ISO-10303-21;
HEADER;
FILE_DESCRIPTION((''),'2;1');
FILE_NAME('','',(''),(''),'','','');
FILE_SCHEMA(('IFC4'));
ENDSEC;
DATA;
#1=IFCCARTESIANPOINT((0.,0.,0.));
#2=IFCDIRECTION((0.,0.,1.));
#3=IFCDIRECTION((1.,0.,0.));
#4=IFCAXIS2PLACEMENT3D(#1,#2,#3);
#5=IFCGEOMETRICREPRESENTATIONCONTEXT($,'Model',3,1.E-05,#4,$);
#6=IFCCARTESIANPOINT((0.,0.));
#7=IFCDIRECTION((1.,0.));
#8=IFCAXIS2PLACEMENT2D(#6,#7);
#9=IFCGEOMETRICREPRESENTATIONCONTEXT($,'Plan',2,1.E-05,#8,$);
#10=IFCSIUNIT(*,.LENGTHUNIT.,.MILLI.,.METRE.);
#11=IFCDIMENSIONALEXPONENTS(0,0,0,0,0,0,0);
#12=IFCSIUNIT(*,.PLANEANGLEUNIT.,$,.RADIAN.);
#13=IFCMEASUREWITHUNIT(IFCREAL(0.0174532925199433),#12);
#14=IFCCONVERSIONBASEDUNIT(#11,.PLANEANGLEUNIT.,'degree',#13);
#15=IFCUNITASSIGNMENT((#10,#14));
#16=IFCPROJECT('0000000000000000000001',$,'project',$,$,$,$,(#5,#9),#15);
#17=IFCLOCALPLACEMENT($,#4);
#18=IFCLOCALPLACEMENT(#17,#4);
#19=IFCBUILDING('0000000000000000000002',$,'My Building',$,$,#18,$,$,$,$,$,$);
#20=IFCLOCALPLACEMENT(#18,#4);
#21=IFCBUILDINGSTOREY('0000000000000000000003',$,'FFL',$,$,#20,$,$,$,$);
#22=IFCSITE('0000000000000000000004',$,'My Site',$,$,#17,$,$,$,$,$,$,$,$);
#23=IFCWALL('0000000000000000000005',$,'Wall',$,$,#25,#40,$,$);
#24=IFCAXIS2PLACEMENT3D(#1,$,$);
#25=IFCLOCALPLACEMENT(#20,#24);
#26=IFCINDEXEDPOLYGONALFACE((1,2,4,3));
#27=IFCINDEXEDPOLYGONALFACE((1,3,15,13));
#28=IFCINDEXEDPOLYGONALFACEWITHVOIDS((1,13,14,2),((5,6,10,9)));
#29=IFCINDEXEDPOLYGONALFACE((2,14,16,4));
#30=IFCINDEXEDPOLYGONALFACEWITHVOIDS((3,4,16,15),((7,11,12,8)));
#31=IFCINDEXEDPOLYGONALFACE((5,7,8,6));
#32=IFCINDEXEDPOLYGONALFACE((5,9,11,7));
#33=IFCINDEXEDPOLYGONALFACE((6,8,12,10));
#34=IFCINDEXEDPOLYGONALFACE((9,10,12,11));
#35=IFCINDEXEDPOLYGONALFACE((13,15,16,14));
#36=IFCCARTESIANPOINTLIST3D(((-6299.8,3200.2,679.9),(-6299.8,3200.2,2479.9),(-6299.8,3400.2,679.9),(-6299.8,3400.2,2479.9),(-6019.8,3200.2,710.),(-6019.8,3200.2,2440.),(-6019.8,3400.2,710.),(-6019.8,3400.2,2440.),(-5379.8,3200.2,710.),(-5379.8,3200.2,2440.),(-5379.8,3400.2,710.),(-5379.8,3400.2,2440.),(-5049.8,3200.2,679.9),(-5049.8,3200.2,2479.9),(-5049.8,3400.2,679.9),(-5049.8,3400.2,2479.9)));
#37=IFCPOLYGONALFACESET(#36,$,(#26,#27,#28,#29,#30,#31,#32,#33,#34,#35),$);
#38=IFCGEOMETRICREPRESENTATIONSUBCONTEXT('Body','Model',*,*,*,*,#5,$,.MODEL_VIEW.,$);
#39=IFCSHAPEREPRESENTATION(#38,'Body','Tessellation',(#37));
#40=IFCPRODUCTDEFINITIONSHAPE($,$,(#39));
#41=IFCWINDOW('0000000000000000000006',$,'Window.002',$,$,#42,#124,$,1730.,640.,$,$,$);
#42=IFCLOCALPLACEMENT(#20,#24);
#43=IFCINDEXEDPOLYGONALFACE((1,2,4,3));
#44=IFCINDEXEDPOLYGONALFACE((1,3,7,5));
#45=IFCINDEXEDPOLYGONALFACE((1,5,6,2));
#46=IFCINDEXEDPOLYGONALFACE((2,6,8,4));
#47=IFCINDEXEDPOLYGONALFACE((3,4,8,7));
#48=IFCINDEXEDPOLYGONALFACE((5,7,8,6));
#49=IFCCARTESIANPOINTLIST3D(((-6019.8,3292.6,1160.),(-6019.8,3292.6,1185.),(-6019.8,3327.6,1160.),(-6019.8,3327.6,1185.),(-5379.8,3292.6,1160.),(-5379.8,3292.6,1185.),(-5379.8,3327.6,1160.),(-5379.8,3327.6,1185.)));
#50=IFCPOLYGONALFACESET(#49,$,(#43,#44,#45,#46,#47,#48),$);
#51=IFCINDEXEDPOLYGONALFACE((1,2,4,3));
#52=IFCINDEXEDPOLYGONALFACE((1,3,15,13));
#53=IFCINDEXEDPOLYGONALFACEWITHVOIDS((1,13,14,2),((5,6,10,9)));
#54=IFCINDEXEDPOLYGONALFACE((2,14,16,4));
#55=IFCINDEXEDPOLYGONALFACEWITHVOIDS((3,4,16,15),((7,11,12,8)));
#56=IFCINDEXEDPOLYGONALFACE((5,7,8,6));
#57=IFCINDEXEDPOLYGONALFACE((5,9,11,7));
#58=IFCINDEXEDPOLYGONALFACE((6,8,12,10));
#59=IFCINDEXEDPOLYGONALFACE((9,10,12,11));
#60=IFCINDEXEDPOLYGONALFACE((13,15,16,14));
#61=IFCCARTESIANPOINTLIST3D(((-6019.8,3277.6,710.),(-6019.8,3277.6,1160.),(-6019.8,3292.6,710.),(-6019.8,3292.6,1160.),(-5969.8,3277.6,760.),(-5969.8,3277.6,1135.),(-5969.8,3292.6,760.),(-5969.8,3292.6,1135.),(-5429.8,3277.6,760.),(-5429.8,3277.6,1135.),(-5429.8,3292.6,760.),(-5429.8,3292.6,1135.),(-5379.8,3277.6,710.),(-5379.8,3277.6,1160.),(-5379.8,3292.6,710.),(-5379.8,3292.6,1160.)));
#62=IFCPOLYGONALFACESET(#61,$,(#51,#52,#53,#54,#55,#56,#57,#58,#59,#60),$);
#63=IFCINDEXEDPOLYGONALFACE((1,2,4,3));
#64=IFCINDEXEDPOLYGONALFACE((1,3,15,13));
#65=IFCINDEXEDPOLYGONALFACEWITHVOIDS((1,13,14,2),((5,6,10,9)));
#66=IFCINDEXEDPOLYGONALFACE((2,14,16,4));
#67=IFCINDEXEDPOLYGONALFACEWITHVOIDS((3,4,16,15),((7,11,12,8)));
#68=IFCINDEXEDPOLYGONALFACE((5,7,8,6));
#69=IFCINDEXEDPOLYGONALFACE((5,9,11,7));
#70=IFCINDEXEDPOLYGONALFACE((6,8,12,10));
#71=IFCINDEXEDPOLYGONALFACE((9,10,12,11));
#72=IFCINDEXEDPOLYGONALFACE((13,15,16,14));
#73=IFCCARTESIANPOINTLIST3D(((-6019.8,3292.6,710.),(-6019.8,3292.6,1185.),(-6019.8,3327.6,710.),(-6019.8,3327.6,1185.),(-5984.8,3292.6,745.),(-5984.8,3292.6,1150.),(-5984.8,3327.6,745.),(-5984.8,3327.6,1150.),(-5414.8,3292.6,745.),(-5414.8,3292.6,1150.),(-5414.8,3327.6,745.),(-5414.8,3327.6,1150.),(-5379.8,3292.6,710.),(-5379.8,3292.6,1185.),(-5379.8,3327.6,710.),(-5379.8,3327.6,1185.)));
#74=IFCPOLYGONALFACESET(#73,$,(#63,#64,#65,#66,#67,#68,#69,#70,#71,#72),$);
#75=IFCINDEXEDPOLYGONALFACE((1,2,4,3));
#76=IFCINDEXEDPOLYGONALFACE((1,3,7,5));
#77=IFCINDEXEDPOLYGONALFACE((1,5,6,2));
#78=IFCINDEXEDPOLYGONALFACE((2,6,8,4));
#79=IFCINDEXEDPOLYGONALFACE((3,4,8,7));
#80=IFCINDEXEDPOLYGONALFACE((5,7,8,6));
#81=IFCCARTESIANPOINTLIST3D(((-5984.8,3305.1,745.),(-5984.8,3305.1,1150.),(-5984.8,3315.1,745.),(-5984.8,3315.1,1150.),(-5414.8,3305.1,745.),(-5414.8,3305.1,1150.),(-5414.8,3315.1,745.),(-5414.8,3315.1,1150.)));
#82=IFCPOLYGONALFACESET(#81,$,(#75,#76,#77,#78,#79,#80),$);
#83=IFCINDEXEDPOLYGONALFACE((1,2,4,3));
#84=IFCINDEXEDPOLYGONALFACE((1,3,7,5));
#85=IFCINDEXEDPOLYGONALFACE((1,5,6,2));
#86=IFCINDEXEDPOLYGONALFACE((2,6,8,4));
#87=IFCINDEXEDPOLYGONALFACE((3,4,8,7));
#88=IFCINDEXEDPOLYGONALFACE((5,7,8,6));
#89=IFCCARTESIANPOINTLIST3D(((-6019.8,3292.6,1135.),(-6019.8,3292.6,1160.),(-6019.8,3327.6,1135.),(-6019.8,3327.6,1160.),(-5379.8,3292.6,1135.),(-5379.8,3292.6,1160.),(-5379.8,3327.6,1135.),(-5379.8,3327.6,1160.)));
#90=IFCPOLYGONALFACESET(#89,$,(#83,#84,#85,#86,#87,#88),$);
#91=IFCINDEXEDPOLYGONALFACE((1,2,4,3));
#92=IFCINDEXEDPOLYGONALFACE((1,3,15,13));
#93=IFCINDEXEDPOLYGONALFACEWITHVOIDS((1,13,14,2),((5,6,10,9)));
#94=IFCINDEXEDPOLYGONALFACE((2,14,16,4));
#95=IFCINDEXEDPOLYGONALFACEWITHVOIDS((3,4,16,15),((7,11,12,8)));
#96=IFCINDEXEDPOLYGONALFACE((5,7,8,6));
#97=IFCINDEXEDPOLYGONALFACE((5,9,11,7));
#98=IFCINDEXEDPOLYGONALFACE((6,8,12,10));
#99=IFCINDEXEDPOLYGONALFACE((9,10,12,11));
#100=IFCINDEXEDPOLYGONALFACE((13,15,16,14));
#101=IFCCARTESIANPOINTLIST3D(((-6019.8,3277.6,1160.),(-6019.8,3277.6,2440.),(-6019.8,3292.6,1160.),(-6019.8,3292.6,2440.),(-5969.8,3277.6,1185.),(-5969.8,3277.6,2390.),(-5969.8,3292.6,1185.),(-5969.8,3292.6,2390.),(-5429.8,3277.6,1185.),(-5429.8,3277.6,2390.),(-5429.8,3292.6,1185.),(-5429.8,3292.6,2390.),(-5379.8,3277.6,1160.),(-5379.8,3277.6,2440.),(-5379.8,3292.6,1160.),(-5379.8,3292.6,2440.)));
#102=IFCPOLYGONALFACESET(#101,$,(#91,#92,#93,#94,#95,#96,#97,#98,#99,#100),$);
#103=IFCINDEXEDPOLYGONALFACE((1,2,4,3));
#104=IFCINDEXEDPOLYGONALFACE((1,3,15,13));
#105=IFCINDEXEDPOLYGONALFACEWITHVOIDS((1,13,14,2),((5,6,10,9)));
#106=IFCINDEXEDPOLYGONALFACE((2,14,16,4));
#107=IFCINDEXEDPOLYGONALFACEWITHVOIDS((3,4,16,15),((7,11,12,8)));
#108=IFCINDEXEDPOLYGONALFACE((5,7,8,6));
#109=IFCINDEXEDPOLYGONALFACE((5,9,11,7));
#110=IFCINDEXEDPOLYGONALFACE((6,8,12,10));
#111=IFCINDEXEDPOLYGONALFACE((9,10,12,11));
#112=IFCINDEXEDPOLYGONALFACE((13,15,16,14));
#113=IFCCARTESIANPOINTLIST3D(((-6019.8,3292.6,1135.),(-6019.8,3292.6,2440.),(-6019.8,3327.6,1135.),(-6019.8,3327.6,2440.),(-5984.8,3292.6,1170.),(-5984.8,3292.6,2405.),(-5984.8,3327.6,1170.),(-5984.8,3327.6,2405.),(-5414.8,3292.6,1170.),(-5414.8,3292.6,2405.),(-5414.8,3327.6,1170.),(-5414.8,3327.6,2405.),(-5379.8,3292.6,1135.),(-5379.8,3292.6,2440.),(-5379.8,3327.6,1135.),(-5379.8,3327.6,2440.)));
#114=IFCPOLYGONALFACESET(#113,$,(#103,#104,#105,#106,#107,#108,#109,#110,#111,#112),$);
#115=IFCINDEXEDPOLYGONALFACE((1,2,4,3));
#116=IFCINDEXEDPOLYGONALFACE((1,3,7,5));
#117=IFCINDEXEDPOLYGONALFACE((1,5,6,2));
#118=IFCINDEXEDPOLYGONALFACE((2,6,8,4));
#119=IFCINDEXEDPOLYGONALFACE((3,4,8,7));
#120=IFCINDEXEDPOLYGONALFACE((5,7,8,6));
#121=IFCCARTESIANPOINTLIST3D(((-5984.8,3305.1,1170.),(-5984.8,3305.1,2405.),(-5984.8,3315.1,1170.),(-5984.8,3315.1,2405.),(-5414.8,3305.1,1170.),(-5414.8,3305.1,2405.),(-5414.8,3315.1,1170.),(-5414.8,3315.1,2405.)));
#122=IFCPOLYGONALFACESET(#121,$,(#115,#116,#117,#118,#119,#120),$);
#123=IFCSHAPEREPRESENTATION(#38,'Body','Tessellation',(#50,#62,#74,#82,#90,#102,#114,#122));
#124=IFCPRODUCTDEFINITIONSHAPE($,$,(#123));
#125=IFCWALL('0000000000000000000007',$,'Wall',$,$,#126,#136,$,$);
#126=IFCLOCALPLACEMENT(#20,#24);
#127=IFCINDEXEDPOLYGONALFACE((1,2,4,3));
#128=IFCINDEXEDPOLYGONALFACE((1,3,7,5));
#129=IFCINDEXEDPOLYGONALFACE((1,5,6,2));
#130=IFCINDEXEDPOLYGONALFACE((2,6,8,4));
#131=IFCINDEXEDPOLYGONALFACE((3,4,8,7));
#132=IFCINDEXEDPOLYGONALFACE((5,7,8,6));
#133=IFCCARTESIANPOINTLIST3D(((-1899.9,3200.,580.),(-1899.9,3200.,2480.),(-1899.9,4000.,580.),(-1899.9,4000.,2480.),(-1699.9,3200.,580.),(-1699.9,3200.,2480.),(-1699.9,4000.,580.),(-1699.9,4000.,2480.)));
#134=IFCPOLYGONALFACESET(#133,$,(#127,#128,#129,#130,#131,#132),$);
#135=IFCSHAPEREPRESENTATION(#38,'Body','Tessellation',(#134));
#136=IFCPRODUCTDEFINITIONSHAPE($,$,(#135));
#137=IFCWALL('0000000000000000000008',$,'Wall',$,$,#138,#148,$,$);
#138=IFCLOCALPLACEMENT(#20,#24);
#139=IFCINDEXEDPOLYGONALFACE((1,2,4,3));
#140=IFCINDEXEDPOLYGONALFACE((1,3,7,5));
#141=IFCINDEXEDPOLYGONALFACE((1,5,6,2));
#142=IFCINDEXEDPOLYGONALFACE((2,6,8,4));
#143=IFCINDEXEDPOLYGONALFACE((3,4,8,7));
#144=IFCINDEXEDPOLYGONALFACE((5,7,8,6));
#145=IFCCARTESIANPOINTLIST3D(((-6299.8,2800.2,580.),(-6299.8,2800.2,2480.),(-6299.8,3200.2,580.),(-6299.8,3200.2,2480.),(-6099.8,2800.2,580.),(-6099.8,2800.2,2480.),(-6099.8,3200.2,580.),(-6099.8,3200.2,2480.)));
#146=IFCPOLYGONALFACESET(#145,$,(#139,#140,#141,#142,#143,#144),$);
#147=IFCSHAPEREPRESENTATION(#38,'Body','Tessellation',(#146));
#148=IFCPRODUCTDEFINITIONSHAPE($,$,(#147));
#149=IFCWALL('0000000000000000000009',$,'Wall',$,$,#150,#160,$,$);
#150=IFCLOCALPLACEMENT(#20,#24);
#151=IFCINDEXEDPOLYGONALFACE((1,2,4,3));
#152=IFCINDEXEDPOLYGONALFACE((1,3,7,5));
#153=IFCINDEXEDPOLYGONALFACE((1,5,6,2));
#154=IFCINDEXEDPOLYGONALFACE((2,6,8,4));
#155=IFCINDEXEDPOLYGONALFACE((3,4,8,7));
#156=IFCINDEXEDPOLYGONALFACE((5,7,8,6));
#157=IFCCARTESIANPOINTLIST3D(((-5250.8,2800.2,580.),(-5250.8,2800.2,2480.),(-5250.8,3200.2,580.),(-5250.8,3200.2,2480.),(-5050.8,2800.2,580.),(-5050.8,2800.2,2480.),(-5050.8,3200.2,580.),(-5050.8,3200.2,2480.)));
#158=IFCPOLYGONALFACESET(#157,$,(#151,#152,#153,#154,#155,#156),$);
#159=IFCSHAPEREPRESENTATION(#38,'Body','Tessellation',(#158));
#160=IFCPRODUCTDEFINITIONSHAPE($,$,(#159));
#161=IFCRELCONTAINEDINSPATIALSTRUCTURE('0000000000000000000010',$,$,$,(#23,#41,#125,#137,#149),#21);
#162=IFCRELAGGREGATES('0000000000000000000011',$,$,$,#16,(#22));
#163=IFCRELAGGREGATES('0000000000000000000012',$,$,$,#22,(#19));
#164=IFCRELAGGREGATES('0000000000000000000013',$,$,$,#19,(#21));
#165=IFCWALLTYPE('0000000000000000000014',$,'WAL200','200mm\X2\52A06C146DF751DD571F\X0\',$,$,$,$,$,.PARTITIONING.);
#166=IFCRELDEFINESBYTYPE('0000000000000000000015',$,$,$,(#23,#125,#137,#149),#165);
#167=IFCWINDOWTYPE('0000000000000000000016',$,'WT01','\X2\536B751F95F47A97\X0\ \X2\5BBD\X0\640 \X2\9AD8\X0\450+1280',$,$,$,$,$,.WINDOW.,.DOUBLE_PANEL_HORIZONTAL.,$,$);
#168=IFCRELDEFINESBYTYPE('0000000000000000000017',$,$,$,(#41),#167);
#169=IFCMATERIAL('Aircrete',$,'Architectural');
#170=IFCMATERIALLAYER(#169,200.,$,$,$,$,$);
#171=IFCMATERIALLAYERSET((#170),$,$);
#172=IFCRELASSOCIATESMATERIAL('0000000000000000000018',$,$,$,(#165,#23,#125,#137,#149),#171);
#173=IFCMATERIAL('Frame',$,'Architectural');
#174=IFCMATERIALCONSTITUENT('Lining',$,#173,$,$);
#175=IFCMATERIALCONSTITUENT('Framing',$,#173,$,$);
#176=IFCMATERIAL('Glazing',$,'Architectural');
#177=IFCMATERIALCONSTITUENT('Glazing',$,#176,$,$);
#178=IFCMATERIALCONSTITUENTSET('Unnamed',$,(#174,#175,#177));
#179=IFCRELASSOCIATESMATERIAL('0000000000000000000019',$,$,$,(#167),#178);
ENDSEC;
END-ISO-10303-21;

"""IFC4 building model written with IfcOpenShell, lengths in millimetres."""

from ifc_helpers import new_model, entity, si_unit, converted_unit, frame, origin_with_axes, origin_2d_with_axis, place, context, subcontext, project, spatial, line, indexed_curve, outline, extrude, shape, source, transform, mapped, material, layer, layer_set, layer_usage, constituent, constituent_set, type_object, type_shapes, element, fill, save


model = new_model("IFC4")

# Units and contexts
model_context = context("Model", 3, precision=1e-05, world=origin_with_axes())
plan_context = context("Plan", 2, precision=1e-05, world=origin_2d_with_axis())
body_context_1 = subcontext(model_context, "Body", "Model", "MODEL_VIEW")
body_context_2 = subcontext(plan_context, "Body", "Plan", "PLAN_VIEW")
ifc_project = project(units=[si_unit("LENGTHUNIT", "METRE", prefix="MILLI"), converted_unit("PLANEANGLEUNIT", "degree", entity("IfcReal", 0.0174532925199433), si_unit("PLANEANGLEUNIT", "RADIAN"), dimensions=[0, 0, 0, 0, 0, 0, 0])], contexts=[model_context, plan_context])

# Site, building, storey
site_placement = place(None, origin_with_axes())
site = spatial("IfcSite", under=ifc_project, at=site_placement, Name="My Site")
building_placement = place(site_placement, origin_with_axes())
building = spatial("IfcBuilding", under=site, at=building_placement, Name="My Building")
storey_placement = place(building_placement, origin_with_axes())
storey = spatial("IfcBuildingStorey", under=building, at=storey_placement, Name="FFL")

# Shared definitions
ifc_material_1 = material(Name="Aircrete", Category="Architectural")

# Shared definitions
ifc_layer_1 = layer(ifc_material_1, 200.0)
ifc_layer_set_1 = layer_set([ifc_layer_1])
wall_type_1 = type_object("IfcWallType", Name="WAL200", Description="200mm加气混凝土", PredefinedType="PARTITIONING", material=ifc_layer_set_1)

# Wall, opening, window
ifc_layer_usage_1 = layer_usage(ifc_layer_set_1, "AXIS2", "NEGATIVE", 0.0)
wall_1_placement = place(storey_placement, frame((-6299.8, 3400.2, 679.9), z_axis=(0.0, 0.0, 1.0), x_axis=(1.0, 0.0, 0.0)))
wall_1 = element("IfcWall", 1, at=wall_1_placement, inside=storey, type_object=wall_type_1, material=ifc_layer_usage_1, Name="Wall", context=body_context_1, shape_type="SweptSolid", body=[
    extrude(outline(indexed_curve([(0.0, -200.0), (0.0, 0.0), (1250.0, 0.0), (1250.0, -200.0)], segments=[line(1, 2, 3, 4, 1)])), origin_with_axes(), (0.0, 0.0, 1.0), 1800.0),
])
shared_shape_1 = source(origin_with_axes(), body_context_1, "Body", "SweptSolid", [
    extrude(outline(indexed_curve([(0.0, 0.0), (640.0, 0.0), (640.0, 1730.0), (0.0, 1730.0)], segments=[line(1, 2, 3, 4, 1)])), frame((0.0, -600.0, 0.0), z_axis=(0.0, -1.0, 0.0), x_axis=(1.0, 0.0, 0.0)), (0.0, 0.0, -1.0), 1200.0),
])
opening_1_placement = place(wall_1_placement, frame((280.0, -172.6, 30.1), z_axis=(0.0, 0.0, 1.0), x_axis=(1.0, 0.0, 0.0)))
opening_1 = element("IfcOpeningElement", 2, at=opening_1_placement, cuts=wall_1, PredefinedType="OPENING", context=body_context_1, shape_type="MappedRepresentation", body=[
    mapped(shared_shape_1, transform((0.0, 0.0, 0.0), x_axis=(1.0, 0.0, 0.0), y_axis=(0.0, 1.0, 0.0), z_axis=(0.0, 0.0, 1.0), scale=1.0)),
])
ifc_material_2 = material(Name="Frame", Category="Architectural")
ifc_constituent_1 = constituent(ifc_material_2, Name="Lining")
ifc_constituent_2 = constituent(ifc_material_2, Name="Framing")
ifc_material_3 = material(Name="Glazing", Category="Architectural")
ifc_constituent_3 = constituent(ifc_material_3, Name="Glazing")
ifc_constituent_set_1 = constituent_set(constituents=[ifc_constituent_1, ifc_constituent_2, ifc_constituent_3], Name="Unnamed")
window_type_1 = type_object("IfcWindowType", Name="WT01", Description="卫生间窗 宽640 高450+1280", PartitioningType="DOUBLE_PANEL_HORIZONTAL", PredefinedType="WINDOW", material=ifc_constituent_set_1)
shared_shape_2 = source(origin_with_axes(), body_context_1, "Body", "SweptSolid", [
    extrude(outline(indexed_curve([(0.0, 450.0), (640.0, 450.0), (640.0, 475.0), (0.0, 475.0)], segments=[line(1, 2, 3, 4, 1)])), frame((0.0, 65.0, 0.0), z_axis=(0.0, -1.0, 0.0), x_axis=(1.0, 0.0, 0.0)), (0.0, 0.0, -1.0), 35.0),
    extrude(outline(indexed_curve([(0.0, 0.0), (640.0, 0.0), (640.0, 450.0), (0.0, 450.0)], segments=[line(1, 2, 3, 4, 1)]), holes=[indexed_curve([(50.0, 50.0), (590.0, 50.0), (590.0, 425.0), (50.0, 425.0)], segments=[line(1, 2, 3, 4, 1)])]), frame((0.0, 50.0, 0.0), z_axis=(0.0, -1.0, 0.0), x_axis=(1.0, 0.0, 0.0)), (0.0, 0.0, -1.0), 15.0),
    extrude(outline(indexed_curve([(0.0, 0.0), (640.0, 0.0), (640.0, 475.0), (0.0, 475.0)], segments=[line(1, 2, 3, 4, 1)]), holes=[indexed_curve([(35.0, 35.0), (605.0, 35.0), (605.0, 440.0), (35.0, 440.0)], segments=[line(1, 2, 3, 4, 1)])]), frame((0.0, 65.0, 0.0), z_axis=(0.0, -1.0, 0.0), x_axis=(1.0, 0.0, 0.0)), (0.0, 0.0, -1.0), 35.0),
    extrude(outline(indexed_curve([(35.0, 35.0), (605.0, 35.0), (605.0, 440.0), (35.0, 440.0)], segments=[line(1, 2, 3, 4, 1)])), frame((0.0, 77.5, 0.0), z_axis=(0.0, -1.0, 0.0), x_axis=(1.0, 0.0, 0.0)), (0.0, 0.0, -1.0), 10.0),
    extrude(outline(indexed_curve([(640.0, 0.0), (0.0, 0.0), (0.0, -25.0), (640.0, -25.0)], segments=[line(1, 2, 3, 4, 1)])), frame((0.0, 65.0, 450.0), z_axis=(0.0, -1.0, 0.0), x_axis=(1.0, 0.0, 0.0)), (0.0, 0.0, -1.0), 35.0),
    extrude(outline(indexed_curve([(0.0, 0.0), (640.0, 0.0), (640.0, 1280.0), (0.0, 1280.0)], segments=[line(1, 2, 3, 4, 1)]), holes=[indexed_curve([(50.0, 25.0), (590.0, 25.0), (590.0, 1230.0), (50.0, 1230.0)], segments=[line(1, 2, 3, 4, 1)])]), frame((0.0, 50.0, 450.0), z_axis=(0.0, -1.0, 0.0), x_axis=(1.0, 0.0, 0.0)), (0.0, 0.0, -1.0), 15.0),
    extrude(outline(indexed_curve([(0.0, 0.0), (640.0, 0.0), (640.0, 1305.0), (0.0, 1305.0)], segments=[line(1, 2, 3, 4, 1)]), holes=[indexed_curve([(35.0, 35.0), (605.0, 35.0), (605.0, 1270.0), (35.0, 1270.0)], segments=[line(1, 2, 3, 4, 1)])]), frame((0.0, 65.0, 425.0), z_axis=(0.0, -1.0, 0.0), x_axis=(1.0, 0.0, 0.0)), (0.0, 0.0, -1.0), 35.0),
    extrude(outline(indexed_curve([(35.0, 35.0), (605.0, 35.0), (605.0, 1270.0), (35.0, 1270.0)], segments=[line(1, 2, 3, 4, 1)])), frame((0.0, 77.5, 425.0), z_axis=(0.0, -1.0, 0.0), x_axis=(1.0, 0.0, 0.0)), (0.0, 0.0, -1.0), 10.0),
])
shared_shape_3 = source(origin_with_axes(), body_context_2, "Body", "Curve2D", [
    entity("IfcIndexedPolyCurve", entity("IfcCartesianPointList2D", [[50.0, 50.0], [590.0, 50.0]])),
    entity("IfcIndexedPolyCurve", entity("IfcCartesianPointList2D", [[0.0, 100.0], [0.0, 100.0], [0.0, 65.0], [50.0, 65.0], [50.0, 50.0], [0.0, 50.0]]), [entity("IfcLineIndex", [1, 2, 3, 4, 5, 6, 1])]),
    entity("IfcIndexedPolyCurve", entity("IfcCartesianPointList2D", [[640.0, 100.0], [640.0, 100.0], [640.0, 65.0], [590.0, 65.0], [590.0, 50.0], [640.0, 50.0]]), [entity("IfcLineIndex", [1, 2, 3, 4, 5, 6, 1])]),
    entity("IfcIndexedPolyCurve", entity("IfcCartesianPointList2D", [[0.0, 65.0], [35.0, 65.0], [35.0, 100.0], [0.0, 100.0]]), [entity("IfcLineIndex", [1, 2, 3, 4, 1])]),
    entity("IfcIndexedPolyCurve", entity("IfcCartesianPointList2D", [[640.0, 65.0], [605.0, 65.0], [605.0, 100.0], [640.0, 100.0]]), [entity("IfcLineIndex", [1, 2, 3, 4, 1])]),
    entity("IfcIndexedPolyCurve", entity("IfcCartesianPointList2D", [[35.0, 65.0], [605.0, 65.0]])),
    entity("IfcIndexedPolyCurve", entity("IfcCartesianPointList2D", [[35.0, 100.0], [605.0, 100.0]])),
    entity("IfcIndexedPolyCurve", entity("IfcCartesianPointList2D", [[35.0, 82.5], [605.0, 82.5]])),
])
type_shapes(window_type_1, [shared_shape_2, shared_shape_3])
window_1_placement = place(opening_1_placement, origin_with_axes())
window_1 = element("IfcWindow", 3, at=window_1_placement, inside=storey, type_object=window_type_1, Name="Window.002", OverallHeight=1730.0, OverallWidth=640.0, shapes=[
    shape(body_context_1, "Body", "MappedRepresentation", [mapped(shared_shape_2, transform((0.0, 0.0, 0.0), x_axis=(1.0, 0.0, 0.0), y_axis=(0.0, 1.0, 0.0), z_axis=(0.0, 0.0, 1.0), scale=1.0))]),
    shape(body_context_2, "Body", "MappedRepresentation", [mapped(shared_shape_3, transform((0.0, 0.0, 0.0), x_axis=(1.0, 0.0, 0.0), y_axis=(0.0, 1.0, 0.0), z_axis=(0.0, 0.0, 1.0), scale=1.0))]),
])
fill(opening_1, window_1)

# Walls
ifc_layer_usage_2 = layer_usage(ifc_layer_set_1, "AXIS2", "NEGATIVE", 0.0)
wall_2_placement = place(storey_placement, frame((-1899.9, 3200.0, 580.0), z_axis=(0.0, 0.0, 1.0), x_axis=(0.0, 1.0, 0.0)))
element("IfcWall", 4, at=wall_2_placement, inside=storey, type_object=wall_type_1, material=ifc_layer_usage_2, Name="Wall", context=body_context_1, shape_type="SweptSolid", body=[
    extrude(outline(indexed_curve([(0.0, -200.0), (0.0, 0.0), (800.0, 0.0), (800.0, -200.0)], segments=[line(1, 2, 3, 4, 1)])), origin_with_axes(), (0.0, 0.0, 1.0), 1900.0),
])
ifc_layer_usage_3 = layer_usage(ifc_layer_set_1, "AXIS2", "NEGATIVE", 0.0)
wall_3_placement = place(storey_placement, frame((-6299.8, 2800.2, 580.0), z_axis=(0.0, 0.0, 1.0), x_axis=(0.0, 1.0, 0.0)))
element("IfcWall", 5, at=wall_3_placement, inside=storey, type_object=wall_type_1, material=ifc_layer_usage_3, Name="Wall", context=body_context_1, shape_type="SweptSolid", body=[
    extrude(outline(indexed_curve([(0.0, -200.0), (0.0, 0.0), (400.0, 0.0), (400.0, -200.0)], segments=[line(1, 2, 3, 4, 1)])), origin_with_axes(), (0.0, 0.0, 1.0), 1900.0),
])
ifc_layer_usage_4 = layer_usage(ifc_layer_set_1, "AXIS2", "NEGATIVE", 0.0)
wall_4_placement = place(storey_placement, frame((-5250.8, 2800.2, 580.0), z_axis=(0.0, 0.0, 1.0), x_axis=(0.0, 1.0, 0.0)))
element("IfcWall", 6, at=wall_4_placement, inside=storey, type_object=wall_type_1, material=ifc_layer_usage_4, Name="Wall", context=body_context_1, shape_type="SweptSolid", body=[
    extrude(outline(indexed_curve([(0.0, -200.0), (0.0, 0.0), (400.0, 0.0), (400.0, -200.0)], segments=[line(1, 2, 3, 4, 1)])), origin_with_axes(), (0.0, 0.0, 1.0), 1900.0),
])

save(model, "model.ifc")
